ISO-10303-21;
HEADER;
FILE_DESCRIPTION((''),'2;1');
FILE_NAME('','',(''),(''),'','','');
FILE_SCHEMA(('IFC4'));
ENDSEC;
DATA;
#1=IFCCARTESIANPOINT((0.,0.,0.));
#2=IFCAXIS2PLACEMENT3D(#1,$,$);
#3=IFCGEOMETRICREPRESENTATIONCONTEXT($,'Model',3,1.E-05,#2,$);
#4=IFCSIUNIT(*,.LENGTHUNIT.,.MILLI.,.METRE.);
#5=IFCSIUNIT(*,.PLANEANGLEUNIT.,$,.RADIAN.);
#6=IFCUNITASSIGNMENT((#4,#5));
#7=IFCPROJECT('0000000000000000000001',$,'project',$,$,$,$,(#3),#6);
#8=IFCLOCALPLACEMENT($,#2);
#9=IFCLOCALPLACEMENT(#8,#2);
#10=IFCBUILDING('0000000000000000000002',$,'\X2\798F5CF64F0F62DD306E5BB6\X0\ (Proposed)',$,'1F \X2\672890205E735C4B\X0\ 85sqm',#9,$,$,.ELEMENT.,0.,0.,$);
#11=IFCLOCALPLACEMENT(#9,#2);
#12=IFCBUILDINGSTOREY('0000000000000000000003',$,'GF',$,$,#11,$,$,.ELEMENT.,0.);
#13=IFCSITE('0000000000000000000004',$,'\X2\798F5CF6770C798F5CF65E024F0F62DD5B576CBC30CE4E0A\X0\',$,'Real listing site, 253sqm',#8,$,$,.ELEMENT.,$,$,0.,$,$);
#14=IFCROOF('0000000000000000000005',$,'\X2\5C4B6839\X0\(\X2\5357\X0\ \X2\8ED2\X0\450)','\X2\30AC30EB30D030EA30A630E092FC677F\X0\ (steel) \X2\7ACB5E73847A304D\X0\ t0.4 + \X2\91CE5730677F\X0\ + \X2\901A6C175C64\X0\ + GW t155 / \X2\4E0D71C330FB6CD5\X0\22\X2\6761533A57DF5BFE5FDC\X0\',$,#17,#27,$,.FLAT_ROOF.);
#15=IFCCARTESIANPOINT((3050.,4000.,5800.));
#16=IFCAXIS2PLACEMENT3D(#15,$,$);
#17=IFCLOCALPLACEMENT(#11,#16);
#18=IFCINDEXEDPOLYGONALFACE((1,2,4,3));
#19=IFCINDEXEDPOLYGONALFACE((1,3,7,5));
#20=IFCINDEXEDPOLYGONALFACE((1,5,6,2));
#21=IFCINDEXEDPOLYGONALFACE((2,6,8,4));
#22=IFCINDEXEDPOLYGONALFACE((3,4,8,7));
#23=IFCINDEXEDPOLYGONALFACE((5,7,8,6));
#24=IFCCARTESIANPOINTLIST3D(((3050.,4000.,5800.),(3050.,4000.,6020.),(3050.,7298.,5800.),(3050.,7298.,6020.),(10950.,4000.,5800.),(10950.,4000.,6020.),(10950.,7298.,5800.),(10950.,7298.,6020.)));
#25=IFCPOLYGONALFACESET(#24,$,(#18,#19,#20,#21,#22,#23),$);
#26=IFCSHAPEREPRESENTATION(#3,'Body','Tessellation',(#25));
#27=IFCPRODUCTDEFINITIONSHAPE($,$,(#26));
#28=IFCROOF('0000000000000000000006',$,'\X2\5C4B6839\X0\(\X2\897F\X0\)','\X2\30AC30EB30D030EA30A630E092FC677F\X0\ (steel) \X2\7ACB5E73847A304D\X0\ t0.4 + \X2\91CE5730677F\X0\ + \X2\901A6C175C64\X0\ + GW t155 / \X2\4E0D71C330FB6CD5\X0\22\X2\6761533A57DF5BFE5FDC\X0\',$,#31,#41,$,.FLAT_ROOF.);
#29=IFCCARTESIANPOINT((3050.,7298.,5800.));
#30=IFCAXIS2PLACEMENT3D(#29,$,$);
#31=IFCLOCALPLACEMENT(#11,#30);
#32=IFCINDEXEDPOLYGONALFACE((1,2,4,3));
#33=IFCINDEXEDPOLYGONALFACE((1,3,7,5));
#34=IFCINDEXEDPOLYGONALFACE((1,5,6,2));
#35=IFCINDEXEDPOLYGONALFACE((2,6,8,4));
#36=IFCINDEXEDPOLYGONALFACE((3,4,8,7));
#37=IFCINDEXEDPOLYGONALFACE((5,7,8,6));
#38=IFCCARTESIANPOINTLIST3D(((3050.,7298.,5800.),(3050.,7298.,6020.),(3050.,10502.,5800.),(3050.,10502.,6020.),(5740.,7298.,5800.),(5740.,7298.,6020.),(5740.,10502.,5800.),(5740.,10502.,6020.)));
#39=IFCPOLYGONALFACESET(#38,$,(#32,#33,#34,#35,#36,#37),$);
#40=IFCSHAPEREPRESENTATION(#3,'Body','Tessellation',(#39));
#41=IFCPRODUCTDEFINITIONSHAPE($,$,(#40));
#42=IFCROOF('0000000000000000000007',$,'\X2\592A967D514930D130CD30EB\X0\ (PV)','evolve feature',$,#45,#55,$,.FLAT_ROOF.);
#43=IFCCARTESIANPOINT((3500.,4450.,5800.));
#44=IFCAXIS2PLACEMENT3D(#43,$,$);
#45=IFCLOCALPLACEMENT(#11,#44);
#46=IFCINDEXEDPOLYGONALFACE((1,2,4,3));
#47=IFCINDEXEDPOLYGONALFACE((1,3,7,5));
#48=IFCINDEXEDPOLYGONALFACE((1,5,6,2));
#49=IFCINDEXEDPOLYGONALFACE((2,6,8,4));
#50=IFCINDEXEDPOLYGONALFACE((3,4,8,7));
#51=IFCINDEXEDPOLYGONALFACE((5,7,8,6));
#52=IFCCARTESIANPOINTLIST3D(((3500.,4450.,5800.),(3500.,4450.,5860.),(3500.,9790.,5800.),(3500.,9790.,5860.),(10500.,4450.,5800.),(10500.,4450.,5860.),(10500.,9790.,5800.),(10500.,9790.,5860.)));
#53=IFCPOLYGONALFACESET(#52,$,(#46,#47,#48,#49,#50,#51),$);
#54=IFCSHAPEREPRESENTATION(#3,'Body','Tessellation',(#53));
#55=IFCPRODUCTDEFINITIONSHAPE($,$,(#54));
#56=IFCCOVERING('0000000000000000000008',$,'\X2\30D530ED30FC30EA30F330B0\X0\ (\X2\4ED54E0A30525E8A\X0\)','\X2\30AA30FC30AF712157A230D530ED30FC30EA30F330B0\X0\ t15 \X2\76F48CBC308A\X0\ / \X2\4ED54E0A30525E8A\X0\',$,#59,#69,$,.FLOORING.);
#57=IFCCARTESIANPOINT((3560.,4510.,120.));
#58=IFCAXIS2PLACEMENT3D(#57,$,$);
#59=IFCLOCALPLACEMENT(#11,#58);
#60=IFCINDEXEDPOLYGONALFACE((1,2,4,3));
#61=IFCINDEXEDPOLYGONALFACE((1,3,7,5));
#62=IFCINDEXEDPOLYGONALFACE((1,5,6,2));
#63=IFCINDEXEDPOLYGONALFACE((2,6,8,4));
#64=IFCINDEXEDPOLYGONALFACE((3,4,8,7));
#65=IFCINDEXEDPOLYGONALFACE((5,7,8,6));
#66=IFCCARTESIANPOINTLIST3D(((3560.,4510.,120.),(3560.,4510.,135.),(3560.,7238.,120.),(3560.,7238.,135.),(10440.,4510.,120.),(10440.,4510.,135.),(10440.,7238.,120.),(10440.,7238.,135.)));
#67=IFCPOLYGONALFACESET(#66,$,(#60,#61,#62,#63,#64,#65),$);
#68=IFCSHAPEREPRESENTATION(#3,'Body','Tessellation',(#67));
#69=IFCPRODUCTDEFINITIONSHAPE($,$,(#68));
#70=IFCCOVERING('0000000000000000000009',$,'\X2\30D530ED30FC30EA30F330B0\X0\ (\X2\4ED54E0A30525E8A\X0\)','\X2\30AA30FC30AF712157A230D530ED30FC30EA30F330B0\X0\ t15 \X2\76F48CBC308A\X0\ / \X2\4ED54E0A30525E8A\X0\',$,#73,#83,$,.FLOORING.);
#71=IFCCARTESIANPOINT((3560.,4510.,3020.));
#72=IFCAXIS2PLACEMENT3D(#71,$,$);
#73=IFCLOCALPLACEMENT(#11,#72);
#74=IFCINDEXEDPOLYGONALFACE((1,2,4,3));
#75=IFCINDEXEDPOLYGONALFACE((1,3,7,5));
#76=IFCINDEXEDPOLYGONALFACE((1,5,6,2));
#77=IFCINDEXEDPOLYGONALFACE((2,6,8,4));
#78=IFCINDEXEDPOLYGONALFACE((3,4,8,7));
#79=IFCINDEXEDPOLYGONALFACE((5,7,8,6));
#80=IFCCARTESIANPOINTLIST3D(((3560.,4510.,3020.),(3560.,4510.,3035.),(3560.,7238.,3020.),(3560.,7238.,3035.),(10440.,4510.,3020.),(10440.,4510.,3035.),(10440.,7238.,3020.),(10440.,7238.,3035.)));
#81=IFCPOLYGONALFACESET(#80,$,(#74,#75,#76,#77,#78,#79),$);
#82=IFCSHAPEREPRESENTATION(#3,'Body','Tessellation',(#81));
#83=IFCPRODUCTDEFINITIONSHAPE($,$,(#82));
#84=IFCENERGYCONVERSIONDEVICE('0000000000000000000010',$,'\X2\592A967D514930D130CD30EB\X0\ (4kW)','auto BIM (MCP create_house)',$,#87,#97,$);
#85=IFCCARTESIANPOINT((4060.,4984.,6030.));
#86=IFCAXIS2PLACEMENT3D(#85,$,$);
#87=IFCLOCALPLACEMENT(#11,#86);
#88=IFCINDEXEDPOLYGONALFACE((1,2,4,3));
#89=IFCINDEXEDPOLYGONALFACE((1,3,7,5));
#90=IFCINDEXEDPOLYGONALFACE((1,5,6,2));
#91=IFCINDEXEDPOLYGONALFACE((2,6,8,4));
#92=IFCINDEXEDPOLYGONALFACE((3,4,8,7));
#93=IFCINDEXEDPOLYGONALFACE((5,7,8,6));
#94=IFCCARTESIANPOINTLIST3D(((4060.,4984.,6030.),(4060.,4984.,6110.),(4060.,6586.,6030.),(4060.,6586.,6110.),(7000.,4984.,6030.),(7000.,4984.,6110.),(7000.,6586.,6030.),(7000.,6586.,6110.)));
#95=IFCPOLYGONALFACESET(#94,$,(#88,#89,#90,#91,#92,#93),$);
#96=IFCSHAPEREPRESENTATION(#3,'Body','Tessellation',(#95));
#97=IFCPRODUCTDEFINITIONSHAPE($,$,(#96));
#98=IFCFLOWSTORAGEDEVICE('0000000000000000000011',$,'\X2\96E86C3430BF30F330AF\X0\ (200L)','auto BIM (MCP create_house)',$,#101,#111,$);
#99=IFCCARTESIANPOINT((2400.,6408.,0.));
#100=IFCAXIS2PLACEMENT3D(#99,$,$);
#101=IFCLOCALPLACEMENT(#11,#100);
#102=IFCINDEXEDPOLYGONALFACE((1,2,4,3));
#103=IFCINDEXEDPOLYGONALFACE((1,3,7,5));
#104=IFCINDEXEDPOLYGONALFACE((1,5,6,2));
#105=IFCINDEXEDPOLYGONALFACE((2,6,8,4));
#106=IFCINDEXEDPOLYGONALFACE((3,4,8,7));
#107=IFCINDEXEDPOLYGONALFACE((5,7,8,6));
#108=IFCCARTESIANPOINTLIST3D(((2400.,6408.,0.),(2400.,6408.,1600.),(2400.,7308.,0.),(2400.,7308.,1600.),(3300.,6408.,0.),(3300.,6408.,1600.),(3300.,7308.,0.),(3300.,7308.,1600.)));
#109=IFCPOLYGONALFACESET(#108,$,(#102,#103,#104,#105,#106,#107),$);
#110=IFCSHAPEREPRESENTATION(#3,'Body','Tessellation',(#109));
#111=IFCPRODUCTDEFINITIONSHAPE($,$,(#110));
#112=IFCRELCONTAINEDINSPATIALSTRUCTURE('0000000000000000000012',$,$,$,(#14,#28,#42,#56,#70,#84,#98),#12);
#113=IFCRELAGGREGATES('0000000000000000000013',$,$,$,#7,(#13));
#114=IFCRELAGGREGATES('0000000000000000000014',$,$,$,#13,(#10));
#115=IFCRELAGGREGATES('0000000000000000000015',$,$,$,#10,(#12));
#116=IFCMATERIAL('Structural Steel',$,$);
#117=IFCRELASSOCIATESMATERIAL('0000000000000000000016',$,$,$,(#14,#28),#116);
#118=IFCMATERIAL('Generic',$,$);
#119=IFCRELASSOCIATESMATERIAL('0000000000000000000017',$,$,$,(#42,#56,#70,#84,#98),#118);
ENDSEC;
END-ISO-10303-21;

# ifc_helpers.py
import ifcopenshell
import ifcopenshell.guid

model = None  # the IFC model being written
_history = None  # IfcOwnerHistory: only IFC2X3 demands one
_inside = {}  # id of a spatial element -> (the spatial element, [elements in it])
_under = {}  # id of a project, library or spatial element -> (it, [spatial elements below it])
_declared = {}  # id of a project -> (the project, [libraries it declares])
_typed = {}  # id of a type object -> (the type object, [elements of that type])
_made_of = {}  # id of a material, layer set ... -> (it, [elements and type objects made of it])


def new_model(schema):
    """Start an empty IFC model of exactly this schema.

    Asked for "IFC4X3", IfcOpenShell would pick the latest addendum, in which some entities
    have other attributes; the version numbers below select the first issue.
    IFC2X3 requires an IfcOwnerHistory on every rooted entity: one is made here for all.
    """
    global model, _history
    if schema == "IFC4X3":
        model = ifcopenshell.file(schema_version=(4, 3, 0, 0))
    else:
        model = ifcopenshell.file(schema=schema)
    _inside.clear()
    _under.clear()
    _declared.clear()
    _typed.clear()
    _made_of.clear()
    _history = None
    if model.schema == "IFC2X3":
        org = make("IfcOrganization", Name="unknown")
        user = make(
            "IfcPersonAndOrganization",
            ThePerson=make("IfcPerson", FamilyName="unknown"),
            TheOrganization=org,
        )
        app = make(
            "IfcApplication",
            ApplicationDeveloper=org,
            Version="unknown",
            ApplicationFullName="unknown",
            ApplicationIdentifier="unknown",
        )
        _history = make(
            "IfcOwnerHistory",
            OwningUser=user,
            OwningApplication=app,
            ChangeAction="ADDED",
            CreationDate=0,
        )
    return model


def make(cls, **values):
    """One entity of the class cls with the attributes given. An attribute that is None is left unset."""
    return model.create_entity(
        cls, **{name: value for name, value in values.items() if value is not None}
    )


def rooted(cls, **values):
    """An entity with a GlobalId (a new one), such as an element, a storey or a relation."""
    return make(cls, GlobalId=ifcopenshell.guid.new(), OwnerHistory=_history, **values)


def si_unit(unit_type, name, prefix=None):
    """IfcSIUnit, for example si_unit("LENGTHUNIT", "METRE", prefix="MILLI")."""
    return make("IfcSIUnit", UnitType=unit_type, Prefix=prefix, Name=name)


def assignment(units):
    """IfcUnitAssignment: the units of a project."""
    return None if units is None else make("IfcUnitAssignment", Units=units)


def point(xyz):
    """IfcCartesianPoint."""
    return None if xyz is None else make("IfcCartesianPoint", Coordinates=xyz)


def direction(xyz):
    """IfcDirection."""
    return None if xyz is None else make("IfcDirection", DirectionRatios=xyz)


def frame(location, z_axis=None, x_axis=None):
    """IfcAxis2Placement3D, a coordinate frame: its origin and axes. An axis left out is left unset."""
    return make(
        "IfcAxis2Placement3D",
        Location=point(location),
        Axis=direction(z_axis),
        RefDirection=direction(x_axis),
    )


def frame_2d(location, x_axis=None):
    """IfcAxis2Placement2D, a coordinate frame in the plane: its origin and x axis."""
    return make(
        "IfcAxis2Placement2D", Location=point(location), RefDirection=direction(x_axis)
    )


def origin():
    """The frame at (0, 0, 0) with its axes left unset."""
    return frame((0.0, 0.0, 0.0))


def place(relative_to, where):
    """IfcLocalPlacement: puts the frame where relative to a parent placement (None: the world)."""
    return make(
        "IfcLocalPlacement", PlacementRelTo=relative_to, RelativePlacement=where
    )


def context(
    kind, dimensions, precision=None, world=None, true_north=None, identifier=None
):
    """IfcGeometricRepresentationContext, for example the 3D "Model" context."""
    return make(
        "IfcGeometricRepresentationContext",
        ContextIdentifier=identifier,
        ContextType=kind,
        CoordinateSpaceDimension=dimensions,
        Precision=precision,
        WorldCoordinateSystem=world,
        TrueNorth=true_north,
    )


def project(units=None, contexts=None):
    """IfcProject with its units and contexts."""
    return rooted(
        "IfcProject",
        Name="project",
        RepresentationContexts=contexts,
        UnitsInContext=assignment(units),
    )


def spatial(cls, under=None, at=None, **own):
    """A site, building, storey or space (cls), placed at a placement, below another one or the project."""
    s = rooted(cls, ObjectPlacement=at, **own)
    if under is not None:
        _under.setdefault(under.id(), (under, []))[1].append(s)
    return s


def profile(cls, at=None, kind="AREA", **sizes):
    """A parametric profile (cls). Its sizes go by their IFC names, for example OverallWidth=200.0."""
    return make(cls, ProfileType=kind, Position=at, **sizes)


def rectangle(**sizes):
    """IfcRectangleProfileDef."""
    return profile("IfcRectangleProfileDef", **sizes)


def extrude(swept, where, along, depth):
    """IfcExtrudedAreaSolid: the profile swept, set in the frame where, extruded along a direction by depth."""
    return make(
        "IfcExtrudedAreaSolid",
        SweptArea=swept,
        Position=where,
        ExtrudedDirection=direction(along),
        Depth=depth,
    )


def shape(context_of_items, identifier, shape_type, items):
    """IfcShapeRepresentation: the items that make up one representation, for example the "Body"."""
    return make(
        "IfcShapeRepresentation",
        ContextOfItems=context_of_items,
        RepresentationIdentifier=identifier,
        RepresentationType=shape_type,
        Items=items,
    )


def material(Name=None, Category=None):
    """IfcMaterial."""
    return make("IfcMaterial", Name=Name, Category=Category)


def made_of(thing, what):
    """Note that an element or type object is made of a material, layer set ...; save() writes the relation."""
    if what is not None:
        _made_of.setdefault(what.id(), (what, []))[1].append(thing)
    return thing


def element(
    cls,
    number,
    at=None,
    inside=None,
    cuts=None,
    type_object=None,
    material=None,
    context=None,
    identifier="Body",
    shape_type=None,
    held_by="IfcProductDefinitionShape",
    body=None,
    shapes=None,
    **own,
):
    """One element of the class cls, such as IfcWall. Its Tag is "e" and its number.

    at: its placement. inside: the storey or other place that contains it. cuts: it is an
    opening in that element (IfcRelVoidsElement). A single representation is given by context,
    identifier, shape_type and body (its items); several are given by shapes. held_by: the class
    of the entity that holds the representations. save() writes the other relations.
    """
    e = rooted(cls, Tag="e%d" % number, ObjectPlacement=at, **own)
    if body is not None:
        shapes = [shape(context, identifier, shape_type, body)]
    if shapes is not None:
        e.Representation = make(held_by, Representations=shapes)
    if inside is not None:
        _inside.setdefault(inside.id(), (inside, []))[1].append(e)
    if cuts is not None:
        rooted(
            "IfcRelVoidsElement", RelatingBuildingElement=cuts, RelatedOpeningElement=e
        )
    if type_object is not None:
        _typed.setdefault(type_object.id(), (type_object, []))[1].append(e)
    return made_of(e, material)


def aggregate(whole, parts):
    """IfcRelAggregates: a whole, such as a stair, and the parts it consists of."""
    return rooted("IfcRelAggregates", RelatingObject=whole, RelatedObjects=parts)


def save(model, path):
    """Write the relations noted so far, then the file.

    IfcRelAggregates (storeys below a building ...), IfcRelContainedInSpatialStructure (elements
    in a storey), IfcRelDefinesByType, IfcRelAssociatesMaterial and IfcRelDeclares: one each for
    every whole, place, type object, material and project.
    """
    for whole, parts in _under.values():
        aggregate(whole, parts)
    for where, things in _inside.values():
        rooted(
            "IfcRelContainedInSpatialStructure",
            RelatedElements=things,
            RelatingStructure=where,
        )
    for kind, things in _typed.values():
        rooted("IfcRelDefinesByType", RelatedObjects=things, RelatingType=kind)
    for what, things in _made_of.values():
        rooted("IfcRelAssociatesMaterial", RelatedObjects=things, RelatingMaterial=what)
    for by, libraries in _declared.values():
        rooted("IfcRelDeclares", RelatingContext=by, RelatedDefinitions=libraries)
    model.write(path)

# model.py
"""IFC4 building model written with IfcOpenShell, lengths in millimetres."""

from ifc_helpers import new_model, si_unit, frame, frame_2d, origin, place, context, project, spatial, rectangle, extrude, material, element, save


model = new_model("IFC4")

# Units and contexts
model_context = context("Model", 3, precision=1e-05, world=origin())
ifc_project = project(units=[si_unit("LENGTHUNIT", "METRE", prefix="MILLI"), si_unit("PLANEANGLEUNIT", "RADIAN")], contexts=[model_context])

# Site, building, storey
site_placement = place(None, origin())
site = spatial("IfcSite", under=ifc_project, at=site_placement, Name="福島県福島市伏拝字沼ノ上", ObjectType="Real listing site, 253sqm", CompositionType="ELEMENT", RefElevation=0.0)
building_placement = place(site_placement, origin())
building = spatial("IfcBuilding", under=site, at=building_placement, Name="福島伏拝の家 (Proposed)", ObjectType="1F 木造平屋 85sqm", CompositionType="ELEMENT", ElevationOfRefHeight=0.0, ElevationOfTerrain=0.0)
storey_placement = place(building_placement, origin())
storey = spatial("IfcBuildingStorey", under=building, at=storey_placement, Name="GF", CompositionType="ELEMENT", Elevation=0.0)

# Shared definitions
ifc_material_1 = material(Name="Generic")

# Roofs
ifc_material_2 = material(Name="Structural Steel")
roof_1_placement = place(storey_placement, frame((3050.0, 4000.0, 5800.0)))
element("IfcRoof", 1, at=roof_1_placement, inside=storey, material=ifc_material_2, Name="屋根(南 軒450)", Description="ガルバリウム鋼板 (steel) 立平葺き t0.4 + 野地板 + 通気層 + GW t155 / 不燃・法22条区域対応", PredefinedType="FLAT_ROOF", context=model_context, shape_type="SweptSolid", body=[
    extrude(rectangle(XDim=7900.0, YDim=3298.0, at=frame_2d((3950.0, 1649.0))), frame((3050.0, 4000.0, 5800.0)), (0.0, 0.0, 1.0), 220.0),
])
roof_2_placement = place(storey_placement, frame((3050.0, 7298.0, 5800.0)))
element("IfcRoof", 2, at=roof_2_placement, inside=storey, material=ifc_material_2, Name="屋根(西)", Description="ガルバリウム鋼板 (steel) 立平葺き t0.4 + 野地板 + 通気層 + GW t155 / 不燃・法22条区域対応", PredefinedType="FLAT_ROOF", context=model_context, shape_type="SweptSolid", body=[
    extrude(rectangle(XDim=2690.0, YDim=3204.0, at=frame_2d((1345.0, 1602.0))), frame((3050.0, 7298.0, 5800.0)), (0.0, 0.0, 1.0), 220.0),
])
roof_3_placement = place(storey_placement, frame((3500.0, 4450.0, 5800.0)))
element("IfcRoof", 3, at=roof_3_placement, inside=storey, material=ifc_material_1, Name="太陽光パネル (PV)", Description="evolve feature", PredefinedType="FLAT_ROOF", context=model_context, shape_type="SweptSolid", body=[
    extrude(rectangle(XDim=7000.0, YDim=5340.0, at=frame_2d((3500.0, 2670.0))), frame((3500.0, 4450.0, 5800.0)), (0.0, 0.0, 1.0), 60.0),
])

# Coverings
covering_1_placement = place(storey_placement, frame((3560.0, 4510.0, 120.0)))
element("IfcCovering", 4, at=covering_1_placement, inside=storey, material=ifc_material_1, Name="フローリング (仕上げ床)", Description="オーク無垢フローリング t15 直貼り / 仕上げ床", PredefinedType="FLOORING", context=model_context, shape_type="SweptSolid", body=[
    extrude(rectangle(XDim=6880.0, YDim=2728.0, at=frame_2d((3440.0, 1364.0))), frame((3560.0, 4510.0, 120.0)), (0.0, 0.0, 1.0), 15.0),
])
covering_2_placement = place(storey_placement, frame((3560.0, 4510.0, 3020.0)))
element("IfcCovering", 5, at=covering_2_placement, inside=storey, material=ifc_material_1, Name="フローリング (仕上げ床)", Description="オーク無垢フローリング t15 直貼り / 仕上げ床", PredefinedType="FLOORING", context=model_context, shape_type="SweptSolid", body=[
    extrude(rectangle(XDim=6880.0, YDim=2728.0, at=frame_2d((3440.0, 1364.0))), frame((3560.0, 4510.0, 3020.0)), (0.0, 0.0, 1.0), 15.0),
])

# Energy conversion device
energy_conversion_device_placement = place(storey_placement, frame((4060.0, 4984.0, 6030.0)))
element("IfcEnergyConversionDevice", 6, at=energy_conversion_device_placement, inside=storey, material=ifc_material_1, Name="太陽光パネル (4kW)", Description="auto BIM (MCP create_house)", context=model_context, shape_type="SweptSolid", body=[
    extrude(rectangle(XDim=2940.0, YDim=1602.0, at=frame_2d((1470.0, 801.0))), frame((4060.0, 4984.0, 6030.0)), (0.0, 0.0, 1.0), 80.0),
])

# Flow storage device
flow_storage_device_placement = place(storey_placement, frame((2400.0, 6408.0, 0.0)))
element("IfcFlowStorageDevice", 7, at=flow_storage_device_placement, inside=storey, material=ifc_material_1, Name="雨水タンク (200L)", Description="auto BIM (MCP create_house)", context=model_context, shape_type="SweptSolid", body=[
    extrude(rectangle(XDim=900.0, YDim=900.0, at=frame_2d((450.0, 450.0))), frame((2400.0, 6408.0, 0.0)), (0.0, 0.0, 1.0), 1600.0),
])

save(model, "model.ifc")
